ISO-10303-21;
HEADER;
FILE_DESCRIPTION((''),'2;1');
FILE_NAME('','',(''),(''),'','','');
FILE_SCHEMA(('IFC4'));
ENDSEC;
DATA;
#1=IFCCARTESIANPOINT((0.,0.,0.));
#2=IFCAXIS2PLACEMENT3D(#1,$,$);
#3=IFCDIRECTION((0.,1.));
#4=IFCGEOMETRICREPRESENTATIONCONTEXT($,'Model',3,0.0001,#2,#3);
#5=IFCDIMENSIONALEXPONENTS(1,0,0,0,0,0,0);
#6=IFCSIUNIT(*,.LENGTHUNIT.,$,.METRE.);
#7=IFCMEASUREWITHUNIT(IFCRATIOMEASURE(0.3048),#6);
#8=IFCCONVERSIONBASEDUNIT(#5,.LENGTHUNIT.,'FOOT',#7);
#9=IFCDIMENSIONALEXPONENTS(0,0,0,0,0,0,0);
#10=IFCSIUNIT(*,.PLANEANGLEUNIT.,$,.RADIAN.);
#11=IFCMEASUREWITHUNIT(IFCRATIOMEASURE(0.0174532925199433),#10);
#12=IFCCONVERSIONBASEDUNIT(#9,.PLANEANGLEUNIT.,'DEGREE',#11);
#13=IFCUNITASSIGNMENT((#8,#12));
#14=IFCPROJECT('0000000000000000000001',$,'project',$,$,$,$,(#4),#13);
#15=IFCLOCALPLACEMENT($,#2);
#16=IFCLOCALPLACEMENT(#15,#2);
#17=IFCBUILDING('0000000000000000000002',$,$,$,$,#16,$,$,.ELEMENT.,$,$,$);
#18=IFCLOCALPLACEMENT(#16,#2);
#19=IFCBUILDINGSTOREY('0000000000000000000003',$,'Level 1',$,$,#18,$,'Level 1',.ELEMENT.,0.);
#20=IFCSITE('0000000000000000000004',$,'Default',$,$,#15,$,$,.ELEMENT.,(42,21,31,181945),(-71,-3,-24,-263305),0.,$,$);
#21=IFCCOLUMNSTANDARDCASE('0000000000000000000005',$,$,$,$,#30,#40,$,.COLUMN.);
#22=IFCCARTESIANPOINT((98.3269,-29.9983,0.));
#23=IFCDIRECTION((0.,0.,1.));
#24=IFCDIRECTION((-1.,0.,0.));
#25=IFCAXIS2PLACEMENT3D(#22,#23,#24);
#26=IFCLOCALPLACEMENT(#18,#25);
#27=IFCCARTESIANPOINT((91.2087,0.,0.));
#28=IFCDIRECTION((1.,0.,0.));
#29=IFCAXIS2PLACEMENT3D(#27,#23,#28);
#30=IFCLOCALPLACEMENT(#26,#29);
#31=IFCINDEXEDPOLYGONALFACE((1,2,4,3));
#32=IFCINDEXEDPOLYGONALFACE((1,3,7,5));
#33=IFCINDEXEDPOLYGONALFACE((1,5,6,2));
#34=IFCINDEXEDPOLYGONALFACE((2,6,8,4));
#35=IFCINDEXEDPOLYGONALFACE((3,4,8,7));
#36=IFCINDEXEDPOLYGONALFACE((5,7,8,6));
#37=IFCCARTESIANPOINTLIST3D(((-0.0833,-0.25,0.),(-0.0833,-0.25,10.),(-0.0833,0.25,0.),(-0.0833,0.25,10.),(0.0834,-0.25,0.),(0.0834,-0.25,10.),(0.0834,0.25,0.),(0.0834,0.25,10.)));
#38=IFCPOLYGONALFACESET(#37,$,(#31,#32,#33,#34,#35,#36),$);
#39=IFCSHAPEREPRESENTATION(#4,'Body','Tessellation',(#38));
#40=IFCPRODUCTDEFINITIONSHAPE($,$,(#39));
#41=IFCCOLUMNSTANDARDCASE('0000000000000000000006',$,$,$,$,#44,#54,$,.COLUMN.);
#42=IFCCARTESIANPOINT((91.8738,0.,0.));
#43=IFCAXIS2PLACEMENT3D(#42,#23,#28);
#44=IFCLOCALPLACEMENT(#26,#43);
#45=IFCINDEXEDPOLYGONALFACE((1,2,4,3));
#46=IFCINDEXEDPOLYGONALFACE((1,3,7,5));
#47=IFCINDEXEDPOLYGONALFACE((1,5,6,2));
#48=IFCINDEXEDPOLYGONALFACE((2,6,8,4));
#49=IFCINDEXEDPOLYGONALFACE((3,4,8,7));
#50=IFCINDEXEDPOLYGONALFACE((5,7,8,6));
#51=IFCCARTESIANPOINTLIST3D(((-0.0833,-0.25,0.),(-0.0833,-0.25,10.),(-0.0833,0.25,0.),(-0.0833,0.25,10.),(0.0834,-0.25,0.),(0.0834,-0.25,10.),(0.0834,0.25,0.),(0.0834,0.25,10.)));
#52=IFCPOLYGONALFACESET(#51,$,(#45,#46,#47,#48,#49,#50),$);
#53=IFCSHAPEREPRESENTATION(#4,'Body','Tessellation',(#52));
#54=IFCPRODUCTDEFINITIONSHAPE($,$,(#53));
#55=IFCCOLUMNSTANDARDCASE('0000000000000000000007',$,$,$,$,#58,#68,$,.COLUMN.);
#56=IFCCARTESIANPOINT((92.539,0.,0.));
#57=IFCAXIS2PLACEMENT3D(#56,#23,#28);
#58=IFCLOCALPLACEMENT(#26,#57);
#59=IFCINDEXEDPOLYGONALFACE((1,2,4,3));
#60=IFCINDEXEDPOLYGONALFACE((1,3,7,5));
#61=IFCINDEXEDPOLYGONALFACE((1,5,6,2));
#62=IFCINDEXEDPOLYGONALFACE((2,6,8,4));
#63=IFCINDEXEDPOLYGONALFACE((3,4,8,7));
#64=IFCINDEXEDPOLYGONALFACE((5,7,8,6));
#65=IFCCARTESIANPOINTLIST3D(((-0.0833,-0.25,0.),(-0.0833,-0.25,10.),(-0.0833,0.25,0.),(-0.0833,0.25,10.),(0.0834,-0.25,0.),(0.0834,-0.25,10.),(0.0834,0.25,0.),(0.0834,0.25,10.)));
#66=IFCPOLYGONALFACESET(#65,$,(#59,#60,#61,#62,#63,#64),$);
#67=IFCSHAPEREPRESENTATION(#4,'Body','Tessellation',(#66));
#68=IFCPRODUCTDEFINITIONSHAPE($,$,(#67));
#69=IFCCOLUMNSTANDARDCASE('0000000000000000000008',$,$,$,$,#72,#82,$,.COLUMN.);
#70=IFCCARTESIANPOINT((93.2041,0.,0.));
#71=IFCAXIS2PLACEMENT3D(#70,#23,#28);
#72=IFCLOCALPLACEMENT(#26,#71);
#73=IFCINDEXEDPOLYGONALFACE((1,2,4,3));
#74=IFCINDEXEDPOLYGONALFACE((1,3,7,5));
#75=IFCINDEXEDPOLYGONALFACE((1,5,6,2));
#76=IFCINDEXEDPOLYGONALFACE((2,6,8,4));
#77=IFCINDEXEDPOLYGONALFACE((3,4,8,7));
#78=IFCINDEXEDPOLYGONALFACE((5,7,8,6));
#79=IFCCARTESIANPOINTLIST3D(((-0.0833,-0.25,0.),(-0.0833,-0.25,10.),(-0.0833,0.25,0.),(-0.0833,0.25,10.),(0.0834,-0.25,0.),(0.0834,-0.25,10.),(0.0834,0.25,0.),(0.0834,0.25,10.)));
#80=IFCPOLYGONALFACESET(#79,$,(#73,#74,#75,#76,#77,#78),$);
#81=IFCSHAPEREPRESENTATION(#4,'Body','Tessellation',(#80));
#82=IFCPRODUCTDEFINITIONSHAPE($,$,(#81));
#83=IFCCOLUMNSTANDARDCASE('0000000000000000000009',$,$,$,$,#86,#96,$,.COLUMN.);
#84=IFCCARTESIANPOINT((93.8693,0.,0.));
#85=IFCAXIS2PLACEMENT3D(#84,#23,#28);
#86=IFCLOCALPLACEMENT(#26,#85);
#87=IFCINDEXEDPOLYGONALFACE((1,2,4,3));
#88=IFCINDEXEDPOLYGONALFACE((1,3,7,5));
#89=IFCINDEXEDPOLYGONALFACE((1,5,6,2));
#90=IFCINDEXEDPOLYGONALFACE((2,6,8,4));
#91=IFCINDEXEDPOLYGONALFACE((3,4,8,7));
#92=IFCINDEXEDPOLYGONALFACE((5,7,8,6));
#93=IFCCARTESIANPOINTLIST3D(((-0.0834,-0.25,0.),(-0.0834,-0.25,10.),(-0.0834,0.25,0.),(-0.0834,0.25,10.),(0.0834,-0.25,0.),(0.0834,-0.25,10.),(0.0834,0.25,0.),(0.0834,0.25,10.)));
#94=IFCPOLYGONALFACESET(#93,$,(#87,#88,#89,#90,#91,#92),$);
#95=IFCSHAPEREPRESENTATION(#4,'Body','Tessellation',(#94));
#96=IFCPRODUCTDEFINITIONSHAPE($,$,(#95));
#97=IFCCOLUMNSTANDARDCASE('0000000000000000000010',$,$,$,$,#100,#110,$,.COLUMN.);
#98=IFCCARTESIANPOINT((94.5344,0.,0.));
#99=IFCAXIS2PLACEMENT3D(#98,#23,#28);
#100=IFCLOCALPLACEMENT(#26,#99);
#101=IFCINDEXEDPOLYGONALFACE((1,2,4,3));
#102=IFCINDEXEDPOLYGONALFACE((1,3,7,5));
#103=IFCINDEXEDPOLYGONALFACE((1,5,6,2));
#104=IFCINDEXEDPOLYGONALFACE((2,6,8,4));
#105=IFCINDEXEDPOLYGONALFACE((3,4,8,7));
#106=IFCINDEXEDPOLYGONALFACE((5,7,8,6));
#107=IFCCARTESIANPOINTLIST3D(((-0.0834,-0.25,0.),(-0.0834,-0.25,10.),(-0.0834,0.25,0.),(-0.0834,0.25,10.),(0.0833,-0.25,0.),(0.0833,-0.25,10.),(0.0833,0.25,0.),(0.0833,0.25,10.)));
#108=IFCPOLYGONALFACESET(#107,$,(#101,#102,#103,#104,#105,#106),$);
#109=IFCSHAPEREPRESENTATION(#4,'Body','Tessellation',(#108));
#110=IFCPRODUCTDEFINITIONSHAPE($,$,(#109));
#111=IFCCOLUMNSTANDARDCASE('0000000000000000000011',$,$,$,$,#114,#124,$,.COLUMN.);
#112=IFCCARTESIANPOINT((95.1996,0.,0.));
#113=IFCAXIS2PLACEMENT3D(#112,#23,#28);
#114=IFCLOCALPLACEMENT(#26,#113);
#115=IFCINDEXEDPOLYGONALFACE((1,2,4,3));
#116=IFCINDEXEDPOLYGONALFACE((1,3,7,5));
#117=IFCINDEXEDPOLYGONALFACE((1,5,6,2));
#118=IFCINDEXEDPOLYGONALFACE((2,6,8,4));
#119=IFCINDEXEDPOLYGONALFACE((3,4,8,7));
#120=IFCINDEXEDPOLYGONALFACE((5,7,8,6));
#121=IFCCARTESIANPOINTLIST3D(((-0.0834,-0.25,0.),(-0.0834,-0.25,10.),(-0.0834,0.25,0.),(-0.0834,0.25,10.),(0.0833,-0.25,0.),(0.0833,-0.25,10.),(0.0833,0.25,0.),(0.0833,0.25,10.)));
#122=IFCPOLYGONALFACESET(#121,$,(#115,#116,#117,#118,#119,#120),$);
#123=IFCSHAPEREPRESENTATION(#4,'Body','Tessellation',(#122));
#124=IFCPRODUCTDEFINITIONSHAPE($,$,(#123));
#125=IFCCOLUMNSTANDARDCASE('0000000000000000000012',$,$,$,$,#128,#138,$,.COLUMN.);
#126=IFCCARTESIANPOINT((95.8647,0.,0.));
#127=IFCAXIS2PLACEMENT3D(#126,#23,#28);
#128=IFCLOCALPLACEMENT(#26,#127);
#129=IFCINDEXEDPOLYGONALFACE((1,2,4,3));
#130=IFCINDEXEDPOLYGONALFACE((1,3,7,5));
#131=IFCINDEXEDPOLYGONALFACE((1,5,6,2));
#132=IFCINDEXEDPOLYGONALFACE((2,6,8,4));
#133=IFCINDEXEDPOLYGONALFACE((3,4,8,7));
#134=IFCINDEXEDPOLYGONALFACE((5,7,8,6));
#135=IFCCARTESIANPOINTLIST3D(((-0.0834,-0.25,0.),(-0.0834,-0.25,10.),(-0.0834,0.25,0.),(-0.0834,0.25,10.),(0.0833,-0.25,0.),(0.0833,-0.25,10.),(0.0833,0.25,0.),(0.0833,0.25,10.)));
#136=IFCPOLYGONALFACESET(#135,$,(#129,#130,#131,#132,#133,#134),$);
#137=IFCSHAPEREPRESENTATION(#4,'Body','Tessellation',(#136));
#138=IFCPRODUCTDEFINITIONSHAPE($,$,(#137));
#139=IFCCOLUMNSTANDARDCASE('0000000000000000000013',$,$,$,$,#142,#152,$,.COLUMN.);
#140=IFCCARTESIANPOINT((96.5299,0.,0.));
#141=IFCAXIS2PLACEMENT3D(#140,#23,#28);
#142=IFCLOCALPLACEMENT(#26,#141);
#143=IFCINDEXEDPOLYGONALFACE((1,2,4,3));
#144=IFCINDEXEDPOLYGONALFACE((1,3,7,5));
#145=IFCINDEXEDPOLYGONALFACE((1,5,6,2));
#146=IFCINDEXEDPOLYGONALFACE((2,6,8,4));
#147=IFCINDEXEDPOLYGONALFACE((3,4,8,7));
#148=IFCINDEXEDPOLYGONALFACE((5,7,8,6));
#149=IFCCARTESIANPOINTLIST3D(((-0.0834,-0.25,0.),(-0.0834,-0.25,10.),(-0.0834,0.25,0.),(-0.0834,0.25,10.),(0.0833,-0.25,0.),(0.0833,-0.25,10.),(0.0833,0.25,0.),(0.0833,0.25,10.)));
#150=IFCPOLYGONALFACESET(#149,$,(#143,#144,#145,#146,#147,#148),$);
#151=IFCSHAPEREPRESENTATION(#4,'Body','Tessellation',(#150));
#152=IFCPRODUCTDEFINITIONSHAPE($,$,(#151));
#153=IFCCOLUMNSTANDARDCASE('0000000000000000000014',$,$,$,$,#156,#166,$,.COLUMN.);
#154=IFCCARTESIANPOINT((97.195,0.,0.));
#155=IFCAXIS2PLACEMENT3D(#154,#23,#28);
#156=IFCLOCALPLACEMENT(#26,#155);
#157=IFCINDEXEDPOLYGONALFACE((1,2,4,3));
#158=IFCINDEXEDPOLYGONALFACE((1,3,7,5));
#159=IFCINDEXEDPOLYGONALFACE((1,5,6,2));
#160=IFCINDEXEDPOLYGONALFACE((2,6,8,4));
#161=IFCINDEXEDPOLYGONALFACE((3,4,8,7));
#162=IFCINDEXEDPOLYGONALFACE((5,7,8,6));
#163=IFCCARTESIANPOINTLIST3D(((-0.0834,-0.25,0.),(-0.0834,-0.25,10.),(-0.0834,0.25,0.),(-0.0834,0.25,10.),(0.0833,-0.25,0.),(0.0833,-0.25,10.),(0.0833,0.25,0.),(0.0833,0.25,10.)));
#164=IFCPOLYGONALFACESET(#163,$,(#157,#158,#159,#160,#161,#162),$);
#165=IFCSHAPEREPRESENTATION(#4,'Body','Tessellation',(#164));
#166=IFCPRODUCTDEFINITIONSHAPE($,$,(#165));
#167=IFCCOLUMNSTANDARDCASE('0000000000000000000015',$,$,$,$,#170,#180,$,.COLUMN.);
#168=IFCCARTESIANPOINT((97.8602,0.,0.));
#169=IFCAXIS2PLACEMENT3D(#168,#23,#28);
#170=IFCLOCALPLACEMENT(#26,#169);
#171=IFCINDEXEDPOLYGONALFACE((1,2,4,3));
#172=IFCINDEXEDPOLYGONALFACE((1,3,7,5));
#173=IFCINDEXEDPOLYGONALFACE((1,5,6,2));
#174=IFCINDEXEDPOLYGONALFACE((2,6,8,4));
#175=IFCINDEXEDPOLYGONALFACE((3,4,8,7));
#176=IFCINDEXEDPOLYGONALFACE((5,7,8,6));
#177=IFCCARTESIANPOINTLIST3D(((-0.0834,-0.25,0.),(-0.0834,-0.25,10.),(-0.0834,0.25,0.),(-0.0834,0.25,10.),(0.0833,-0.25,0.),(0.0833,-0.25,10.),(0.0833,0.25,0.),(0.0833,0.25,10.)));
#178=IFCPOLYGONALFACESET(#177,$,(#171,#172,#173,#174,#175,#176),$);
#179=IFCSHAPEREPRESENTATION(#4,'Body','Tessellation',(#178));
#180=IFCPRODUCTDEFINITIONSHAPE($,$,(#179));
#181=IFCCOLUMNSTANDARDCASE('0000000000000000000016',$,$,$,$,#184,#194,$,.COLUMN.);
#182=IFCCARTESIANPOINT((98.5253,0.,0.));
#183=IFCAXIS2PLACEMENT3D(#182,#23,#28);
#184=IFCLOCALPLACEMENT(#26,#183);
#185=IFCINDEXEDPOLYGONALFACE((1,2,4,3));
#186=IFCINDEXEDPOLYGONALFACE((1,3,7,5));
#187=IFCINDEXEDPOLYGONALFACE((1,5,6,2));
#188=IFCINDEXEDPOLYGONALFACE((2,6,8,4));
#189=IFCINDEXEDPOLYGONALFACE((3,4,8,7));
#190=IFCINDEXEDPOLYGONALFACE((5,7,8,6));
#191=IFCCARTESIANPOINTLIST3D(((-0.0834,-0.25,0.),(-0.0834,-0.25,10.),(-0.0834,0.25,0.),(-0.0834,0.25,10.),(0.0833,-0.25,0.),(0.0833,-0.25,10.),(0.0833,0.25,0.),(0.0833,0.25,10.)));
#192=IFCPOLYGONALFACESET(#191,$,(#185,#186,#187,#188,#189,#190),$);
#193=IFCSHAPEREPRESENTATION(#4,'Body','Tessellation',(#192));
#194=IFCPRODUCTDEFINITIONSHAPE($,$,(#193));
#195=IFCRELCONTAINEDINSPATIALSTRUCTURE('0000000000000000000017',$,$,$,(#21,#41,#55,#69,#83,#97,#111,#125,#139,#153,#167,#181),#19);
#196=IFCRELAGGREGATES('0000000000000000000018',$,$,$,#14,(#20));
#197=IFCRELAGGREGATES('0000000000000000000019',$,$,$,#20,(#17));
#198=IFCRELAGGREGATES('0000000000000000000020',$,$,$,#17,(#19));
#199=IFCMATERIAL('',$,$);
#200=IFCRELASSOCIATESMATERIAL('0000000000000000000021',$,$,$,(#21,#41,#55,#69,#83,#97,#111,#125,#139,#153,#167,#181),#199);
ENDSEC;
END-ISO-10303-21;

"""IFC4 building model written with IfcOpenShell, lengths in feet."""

from ifc_helpers import new_model, entity, si_unit, converted_unit, direction, frame, origin, place, context, project, spatial, rectangle, extrude, material, element, save


model = new_model("IFC4")

# Units and contexts
model_context = context("Model", 3, precision=0.0001, world=origin(), true_north=direction((0.0, 1.0)))
ifc_project = project(units=[converted_unit("LENGTHUNIT", "FOOT", entity("IfcRatioMeasure", 0.3048), si_unit("LENGTHUNIT", "METRE"), dimensions=[1, 0, 0, 0, 0, 0, 0]), converted_unit("PLANEANGLEUNIT", "DEGREE", entity("IfcRatioMeasure", 0.0174532925199433), si_unit("PLANEANGLEUNIT", "RADIAN"), dimensions=[0, 0, 0, 0, 0, 0, 0])], contexts=[model_context])

# Site, building, storey
site_placement = place(None, origin())
site = spatial("IfcSite", under=ifc_project, at=site_placement, Name="Default", CompositionType="ELEMENT", RefLatitude=(42, 21, 31, 181945), RefLongitude=(-71, -3, -24, -263305), RefElevation=0.0)
building_placement = place(site_placement, origin())
building = spatial("IfcBuilding", under=site, at=building_placement, CompositionType="ELEMENT")
storey_placement = place(building_placement, origin())
storey = spatial("IfcBuildingStorey", under=building, at=storey_placement, Name="Level 1", LongName="Level 1", CompositionType="ELEMENT", Elevation=0.0)

# Columns
ifc_material = material(Name="")
placement = place(storey_placement, frame((98.3269, -29.9983, 0.0), z_axis=(0.0, 0.0, 1.0), x_axis=(-1.0, 0.0, 0.0)))
for number, where, z_axis, x_axis in (
    (1, (91.2087, 0.0, 0.0), (0.0, 0.0, 1.0), (1.0, 0.0, 0.0)),
    (2, (91.8738, 0.0, 0.0), (0.0, 0.0, 1.0), (1.0, 0.0, 0.0)),
    (3, (92.539, 0.0, 0.0), (0.0, 0.0, 1.0), (1.0, 0.0, 0.0)),
    (4, (93.2041, 0.0, 0.0), (0.0, 0.0, 1.0), (1.0, 0.0, 0.0)),
    (5, (93.8693, 0.0, 0.0), (0.0, 0.0, 1.0), (1.0, 0.0, 0.0)),
    (6, (94.5344, 0.0, 0.0), (0.0, 0.0, 1.0), (1.0, 0.0, 0.0)),
    (7, (95.1996, 0.0, 0.0), (0.0, 0.0, 1.0), (1.0, 0.0, 0.0)),
    (8, (95.8647, 0.0, 0.0), (0.0, 0.0, 1.0), (1.0, 0.0, 0.0)),
    (9, (96.5299, 0.0, 0.0), (0.0, 0.0, 1.0), (1.0, 0.0, 0.0)),
    (10, (97.195, 0.0, 0.0), (0.0, 0.0, 1.0), (1.0, 0.0, 0.0)),
    (11, (97.8602, 0.0, 0.0), (0.0, 0.0, 1.0), (1.0, 0.0, 0.0)),
    (12, (98.5253, 0.0, 0.0), (0.0, 0.0, 1.0), (1.0, 0.0, 0.0)),
):
    element("IfcColumnStandardCase", number, at=place(placement, frame(where, z_axis=z_axis, x_axis=x_axis)), inside=storey, material=ifc_material, PredefinedType="COLUMN", context=model_context, shape_type="SweptSolid", body=[
        extrude(rectangle(XDim=0.1667, YDim=0.5), origin(), (0.0, 0.0, 1.0), 10.0),
    ])

save(model, "model.ifc")
